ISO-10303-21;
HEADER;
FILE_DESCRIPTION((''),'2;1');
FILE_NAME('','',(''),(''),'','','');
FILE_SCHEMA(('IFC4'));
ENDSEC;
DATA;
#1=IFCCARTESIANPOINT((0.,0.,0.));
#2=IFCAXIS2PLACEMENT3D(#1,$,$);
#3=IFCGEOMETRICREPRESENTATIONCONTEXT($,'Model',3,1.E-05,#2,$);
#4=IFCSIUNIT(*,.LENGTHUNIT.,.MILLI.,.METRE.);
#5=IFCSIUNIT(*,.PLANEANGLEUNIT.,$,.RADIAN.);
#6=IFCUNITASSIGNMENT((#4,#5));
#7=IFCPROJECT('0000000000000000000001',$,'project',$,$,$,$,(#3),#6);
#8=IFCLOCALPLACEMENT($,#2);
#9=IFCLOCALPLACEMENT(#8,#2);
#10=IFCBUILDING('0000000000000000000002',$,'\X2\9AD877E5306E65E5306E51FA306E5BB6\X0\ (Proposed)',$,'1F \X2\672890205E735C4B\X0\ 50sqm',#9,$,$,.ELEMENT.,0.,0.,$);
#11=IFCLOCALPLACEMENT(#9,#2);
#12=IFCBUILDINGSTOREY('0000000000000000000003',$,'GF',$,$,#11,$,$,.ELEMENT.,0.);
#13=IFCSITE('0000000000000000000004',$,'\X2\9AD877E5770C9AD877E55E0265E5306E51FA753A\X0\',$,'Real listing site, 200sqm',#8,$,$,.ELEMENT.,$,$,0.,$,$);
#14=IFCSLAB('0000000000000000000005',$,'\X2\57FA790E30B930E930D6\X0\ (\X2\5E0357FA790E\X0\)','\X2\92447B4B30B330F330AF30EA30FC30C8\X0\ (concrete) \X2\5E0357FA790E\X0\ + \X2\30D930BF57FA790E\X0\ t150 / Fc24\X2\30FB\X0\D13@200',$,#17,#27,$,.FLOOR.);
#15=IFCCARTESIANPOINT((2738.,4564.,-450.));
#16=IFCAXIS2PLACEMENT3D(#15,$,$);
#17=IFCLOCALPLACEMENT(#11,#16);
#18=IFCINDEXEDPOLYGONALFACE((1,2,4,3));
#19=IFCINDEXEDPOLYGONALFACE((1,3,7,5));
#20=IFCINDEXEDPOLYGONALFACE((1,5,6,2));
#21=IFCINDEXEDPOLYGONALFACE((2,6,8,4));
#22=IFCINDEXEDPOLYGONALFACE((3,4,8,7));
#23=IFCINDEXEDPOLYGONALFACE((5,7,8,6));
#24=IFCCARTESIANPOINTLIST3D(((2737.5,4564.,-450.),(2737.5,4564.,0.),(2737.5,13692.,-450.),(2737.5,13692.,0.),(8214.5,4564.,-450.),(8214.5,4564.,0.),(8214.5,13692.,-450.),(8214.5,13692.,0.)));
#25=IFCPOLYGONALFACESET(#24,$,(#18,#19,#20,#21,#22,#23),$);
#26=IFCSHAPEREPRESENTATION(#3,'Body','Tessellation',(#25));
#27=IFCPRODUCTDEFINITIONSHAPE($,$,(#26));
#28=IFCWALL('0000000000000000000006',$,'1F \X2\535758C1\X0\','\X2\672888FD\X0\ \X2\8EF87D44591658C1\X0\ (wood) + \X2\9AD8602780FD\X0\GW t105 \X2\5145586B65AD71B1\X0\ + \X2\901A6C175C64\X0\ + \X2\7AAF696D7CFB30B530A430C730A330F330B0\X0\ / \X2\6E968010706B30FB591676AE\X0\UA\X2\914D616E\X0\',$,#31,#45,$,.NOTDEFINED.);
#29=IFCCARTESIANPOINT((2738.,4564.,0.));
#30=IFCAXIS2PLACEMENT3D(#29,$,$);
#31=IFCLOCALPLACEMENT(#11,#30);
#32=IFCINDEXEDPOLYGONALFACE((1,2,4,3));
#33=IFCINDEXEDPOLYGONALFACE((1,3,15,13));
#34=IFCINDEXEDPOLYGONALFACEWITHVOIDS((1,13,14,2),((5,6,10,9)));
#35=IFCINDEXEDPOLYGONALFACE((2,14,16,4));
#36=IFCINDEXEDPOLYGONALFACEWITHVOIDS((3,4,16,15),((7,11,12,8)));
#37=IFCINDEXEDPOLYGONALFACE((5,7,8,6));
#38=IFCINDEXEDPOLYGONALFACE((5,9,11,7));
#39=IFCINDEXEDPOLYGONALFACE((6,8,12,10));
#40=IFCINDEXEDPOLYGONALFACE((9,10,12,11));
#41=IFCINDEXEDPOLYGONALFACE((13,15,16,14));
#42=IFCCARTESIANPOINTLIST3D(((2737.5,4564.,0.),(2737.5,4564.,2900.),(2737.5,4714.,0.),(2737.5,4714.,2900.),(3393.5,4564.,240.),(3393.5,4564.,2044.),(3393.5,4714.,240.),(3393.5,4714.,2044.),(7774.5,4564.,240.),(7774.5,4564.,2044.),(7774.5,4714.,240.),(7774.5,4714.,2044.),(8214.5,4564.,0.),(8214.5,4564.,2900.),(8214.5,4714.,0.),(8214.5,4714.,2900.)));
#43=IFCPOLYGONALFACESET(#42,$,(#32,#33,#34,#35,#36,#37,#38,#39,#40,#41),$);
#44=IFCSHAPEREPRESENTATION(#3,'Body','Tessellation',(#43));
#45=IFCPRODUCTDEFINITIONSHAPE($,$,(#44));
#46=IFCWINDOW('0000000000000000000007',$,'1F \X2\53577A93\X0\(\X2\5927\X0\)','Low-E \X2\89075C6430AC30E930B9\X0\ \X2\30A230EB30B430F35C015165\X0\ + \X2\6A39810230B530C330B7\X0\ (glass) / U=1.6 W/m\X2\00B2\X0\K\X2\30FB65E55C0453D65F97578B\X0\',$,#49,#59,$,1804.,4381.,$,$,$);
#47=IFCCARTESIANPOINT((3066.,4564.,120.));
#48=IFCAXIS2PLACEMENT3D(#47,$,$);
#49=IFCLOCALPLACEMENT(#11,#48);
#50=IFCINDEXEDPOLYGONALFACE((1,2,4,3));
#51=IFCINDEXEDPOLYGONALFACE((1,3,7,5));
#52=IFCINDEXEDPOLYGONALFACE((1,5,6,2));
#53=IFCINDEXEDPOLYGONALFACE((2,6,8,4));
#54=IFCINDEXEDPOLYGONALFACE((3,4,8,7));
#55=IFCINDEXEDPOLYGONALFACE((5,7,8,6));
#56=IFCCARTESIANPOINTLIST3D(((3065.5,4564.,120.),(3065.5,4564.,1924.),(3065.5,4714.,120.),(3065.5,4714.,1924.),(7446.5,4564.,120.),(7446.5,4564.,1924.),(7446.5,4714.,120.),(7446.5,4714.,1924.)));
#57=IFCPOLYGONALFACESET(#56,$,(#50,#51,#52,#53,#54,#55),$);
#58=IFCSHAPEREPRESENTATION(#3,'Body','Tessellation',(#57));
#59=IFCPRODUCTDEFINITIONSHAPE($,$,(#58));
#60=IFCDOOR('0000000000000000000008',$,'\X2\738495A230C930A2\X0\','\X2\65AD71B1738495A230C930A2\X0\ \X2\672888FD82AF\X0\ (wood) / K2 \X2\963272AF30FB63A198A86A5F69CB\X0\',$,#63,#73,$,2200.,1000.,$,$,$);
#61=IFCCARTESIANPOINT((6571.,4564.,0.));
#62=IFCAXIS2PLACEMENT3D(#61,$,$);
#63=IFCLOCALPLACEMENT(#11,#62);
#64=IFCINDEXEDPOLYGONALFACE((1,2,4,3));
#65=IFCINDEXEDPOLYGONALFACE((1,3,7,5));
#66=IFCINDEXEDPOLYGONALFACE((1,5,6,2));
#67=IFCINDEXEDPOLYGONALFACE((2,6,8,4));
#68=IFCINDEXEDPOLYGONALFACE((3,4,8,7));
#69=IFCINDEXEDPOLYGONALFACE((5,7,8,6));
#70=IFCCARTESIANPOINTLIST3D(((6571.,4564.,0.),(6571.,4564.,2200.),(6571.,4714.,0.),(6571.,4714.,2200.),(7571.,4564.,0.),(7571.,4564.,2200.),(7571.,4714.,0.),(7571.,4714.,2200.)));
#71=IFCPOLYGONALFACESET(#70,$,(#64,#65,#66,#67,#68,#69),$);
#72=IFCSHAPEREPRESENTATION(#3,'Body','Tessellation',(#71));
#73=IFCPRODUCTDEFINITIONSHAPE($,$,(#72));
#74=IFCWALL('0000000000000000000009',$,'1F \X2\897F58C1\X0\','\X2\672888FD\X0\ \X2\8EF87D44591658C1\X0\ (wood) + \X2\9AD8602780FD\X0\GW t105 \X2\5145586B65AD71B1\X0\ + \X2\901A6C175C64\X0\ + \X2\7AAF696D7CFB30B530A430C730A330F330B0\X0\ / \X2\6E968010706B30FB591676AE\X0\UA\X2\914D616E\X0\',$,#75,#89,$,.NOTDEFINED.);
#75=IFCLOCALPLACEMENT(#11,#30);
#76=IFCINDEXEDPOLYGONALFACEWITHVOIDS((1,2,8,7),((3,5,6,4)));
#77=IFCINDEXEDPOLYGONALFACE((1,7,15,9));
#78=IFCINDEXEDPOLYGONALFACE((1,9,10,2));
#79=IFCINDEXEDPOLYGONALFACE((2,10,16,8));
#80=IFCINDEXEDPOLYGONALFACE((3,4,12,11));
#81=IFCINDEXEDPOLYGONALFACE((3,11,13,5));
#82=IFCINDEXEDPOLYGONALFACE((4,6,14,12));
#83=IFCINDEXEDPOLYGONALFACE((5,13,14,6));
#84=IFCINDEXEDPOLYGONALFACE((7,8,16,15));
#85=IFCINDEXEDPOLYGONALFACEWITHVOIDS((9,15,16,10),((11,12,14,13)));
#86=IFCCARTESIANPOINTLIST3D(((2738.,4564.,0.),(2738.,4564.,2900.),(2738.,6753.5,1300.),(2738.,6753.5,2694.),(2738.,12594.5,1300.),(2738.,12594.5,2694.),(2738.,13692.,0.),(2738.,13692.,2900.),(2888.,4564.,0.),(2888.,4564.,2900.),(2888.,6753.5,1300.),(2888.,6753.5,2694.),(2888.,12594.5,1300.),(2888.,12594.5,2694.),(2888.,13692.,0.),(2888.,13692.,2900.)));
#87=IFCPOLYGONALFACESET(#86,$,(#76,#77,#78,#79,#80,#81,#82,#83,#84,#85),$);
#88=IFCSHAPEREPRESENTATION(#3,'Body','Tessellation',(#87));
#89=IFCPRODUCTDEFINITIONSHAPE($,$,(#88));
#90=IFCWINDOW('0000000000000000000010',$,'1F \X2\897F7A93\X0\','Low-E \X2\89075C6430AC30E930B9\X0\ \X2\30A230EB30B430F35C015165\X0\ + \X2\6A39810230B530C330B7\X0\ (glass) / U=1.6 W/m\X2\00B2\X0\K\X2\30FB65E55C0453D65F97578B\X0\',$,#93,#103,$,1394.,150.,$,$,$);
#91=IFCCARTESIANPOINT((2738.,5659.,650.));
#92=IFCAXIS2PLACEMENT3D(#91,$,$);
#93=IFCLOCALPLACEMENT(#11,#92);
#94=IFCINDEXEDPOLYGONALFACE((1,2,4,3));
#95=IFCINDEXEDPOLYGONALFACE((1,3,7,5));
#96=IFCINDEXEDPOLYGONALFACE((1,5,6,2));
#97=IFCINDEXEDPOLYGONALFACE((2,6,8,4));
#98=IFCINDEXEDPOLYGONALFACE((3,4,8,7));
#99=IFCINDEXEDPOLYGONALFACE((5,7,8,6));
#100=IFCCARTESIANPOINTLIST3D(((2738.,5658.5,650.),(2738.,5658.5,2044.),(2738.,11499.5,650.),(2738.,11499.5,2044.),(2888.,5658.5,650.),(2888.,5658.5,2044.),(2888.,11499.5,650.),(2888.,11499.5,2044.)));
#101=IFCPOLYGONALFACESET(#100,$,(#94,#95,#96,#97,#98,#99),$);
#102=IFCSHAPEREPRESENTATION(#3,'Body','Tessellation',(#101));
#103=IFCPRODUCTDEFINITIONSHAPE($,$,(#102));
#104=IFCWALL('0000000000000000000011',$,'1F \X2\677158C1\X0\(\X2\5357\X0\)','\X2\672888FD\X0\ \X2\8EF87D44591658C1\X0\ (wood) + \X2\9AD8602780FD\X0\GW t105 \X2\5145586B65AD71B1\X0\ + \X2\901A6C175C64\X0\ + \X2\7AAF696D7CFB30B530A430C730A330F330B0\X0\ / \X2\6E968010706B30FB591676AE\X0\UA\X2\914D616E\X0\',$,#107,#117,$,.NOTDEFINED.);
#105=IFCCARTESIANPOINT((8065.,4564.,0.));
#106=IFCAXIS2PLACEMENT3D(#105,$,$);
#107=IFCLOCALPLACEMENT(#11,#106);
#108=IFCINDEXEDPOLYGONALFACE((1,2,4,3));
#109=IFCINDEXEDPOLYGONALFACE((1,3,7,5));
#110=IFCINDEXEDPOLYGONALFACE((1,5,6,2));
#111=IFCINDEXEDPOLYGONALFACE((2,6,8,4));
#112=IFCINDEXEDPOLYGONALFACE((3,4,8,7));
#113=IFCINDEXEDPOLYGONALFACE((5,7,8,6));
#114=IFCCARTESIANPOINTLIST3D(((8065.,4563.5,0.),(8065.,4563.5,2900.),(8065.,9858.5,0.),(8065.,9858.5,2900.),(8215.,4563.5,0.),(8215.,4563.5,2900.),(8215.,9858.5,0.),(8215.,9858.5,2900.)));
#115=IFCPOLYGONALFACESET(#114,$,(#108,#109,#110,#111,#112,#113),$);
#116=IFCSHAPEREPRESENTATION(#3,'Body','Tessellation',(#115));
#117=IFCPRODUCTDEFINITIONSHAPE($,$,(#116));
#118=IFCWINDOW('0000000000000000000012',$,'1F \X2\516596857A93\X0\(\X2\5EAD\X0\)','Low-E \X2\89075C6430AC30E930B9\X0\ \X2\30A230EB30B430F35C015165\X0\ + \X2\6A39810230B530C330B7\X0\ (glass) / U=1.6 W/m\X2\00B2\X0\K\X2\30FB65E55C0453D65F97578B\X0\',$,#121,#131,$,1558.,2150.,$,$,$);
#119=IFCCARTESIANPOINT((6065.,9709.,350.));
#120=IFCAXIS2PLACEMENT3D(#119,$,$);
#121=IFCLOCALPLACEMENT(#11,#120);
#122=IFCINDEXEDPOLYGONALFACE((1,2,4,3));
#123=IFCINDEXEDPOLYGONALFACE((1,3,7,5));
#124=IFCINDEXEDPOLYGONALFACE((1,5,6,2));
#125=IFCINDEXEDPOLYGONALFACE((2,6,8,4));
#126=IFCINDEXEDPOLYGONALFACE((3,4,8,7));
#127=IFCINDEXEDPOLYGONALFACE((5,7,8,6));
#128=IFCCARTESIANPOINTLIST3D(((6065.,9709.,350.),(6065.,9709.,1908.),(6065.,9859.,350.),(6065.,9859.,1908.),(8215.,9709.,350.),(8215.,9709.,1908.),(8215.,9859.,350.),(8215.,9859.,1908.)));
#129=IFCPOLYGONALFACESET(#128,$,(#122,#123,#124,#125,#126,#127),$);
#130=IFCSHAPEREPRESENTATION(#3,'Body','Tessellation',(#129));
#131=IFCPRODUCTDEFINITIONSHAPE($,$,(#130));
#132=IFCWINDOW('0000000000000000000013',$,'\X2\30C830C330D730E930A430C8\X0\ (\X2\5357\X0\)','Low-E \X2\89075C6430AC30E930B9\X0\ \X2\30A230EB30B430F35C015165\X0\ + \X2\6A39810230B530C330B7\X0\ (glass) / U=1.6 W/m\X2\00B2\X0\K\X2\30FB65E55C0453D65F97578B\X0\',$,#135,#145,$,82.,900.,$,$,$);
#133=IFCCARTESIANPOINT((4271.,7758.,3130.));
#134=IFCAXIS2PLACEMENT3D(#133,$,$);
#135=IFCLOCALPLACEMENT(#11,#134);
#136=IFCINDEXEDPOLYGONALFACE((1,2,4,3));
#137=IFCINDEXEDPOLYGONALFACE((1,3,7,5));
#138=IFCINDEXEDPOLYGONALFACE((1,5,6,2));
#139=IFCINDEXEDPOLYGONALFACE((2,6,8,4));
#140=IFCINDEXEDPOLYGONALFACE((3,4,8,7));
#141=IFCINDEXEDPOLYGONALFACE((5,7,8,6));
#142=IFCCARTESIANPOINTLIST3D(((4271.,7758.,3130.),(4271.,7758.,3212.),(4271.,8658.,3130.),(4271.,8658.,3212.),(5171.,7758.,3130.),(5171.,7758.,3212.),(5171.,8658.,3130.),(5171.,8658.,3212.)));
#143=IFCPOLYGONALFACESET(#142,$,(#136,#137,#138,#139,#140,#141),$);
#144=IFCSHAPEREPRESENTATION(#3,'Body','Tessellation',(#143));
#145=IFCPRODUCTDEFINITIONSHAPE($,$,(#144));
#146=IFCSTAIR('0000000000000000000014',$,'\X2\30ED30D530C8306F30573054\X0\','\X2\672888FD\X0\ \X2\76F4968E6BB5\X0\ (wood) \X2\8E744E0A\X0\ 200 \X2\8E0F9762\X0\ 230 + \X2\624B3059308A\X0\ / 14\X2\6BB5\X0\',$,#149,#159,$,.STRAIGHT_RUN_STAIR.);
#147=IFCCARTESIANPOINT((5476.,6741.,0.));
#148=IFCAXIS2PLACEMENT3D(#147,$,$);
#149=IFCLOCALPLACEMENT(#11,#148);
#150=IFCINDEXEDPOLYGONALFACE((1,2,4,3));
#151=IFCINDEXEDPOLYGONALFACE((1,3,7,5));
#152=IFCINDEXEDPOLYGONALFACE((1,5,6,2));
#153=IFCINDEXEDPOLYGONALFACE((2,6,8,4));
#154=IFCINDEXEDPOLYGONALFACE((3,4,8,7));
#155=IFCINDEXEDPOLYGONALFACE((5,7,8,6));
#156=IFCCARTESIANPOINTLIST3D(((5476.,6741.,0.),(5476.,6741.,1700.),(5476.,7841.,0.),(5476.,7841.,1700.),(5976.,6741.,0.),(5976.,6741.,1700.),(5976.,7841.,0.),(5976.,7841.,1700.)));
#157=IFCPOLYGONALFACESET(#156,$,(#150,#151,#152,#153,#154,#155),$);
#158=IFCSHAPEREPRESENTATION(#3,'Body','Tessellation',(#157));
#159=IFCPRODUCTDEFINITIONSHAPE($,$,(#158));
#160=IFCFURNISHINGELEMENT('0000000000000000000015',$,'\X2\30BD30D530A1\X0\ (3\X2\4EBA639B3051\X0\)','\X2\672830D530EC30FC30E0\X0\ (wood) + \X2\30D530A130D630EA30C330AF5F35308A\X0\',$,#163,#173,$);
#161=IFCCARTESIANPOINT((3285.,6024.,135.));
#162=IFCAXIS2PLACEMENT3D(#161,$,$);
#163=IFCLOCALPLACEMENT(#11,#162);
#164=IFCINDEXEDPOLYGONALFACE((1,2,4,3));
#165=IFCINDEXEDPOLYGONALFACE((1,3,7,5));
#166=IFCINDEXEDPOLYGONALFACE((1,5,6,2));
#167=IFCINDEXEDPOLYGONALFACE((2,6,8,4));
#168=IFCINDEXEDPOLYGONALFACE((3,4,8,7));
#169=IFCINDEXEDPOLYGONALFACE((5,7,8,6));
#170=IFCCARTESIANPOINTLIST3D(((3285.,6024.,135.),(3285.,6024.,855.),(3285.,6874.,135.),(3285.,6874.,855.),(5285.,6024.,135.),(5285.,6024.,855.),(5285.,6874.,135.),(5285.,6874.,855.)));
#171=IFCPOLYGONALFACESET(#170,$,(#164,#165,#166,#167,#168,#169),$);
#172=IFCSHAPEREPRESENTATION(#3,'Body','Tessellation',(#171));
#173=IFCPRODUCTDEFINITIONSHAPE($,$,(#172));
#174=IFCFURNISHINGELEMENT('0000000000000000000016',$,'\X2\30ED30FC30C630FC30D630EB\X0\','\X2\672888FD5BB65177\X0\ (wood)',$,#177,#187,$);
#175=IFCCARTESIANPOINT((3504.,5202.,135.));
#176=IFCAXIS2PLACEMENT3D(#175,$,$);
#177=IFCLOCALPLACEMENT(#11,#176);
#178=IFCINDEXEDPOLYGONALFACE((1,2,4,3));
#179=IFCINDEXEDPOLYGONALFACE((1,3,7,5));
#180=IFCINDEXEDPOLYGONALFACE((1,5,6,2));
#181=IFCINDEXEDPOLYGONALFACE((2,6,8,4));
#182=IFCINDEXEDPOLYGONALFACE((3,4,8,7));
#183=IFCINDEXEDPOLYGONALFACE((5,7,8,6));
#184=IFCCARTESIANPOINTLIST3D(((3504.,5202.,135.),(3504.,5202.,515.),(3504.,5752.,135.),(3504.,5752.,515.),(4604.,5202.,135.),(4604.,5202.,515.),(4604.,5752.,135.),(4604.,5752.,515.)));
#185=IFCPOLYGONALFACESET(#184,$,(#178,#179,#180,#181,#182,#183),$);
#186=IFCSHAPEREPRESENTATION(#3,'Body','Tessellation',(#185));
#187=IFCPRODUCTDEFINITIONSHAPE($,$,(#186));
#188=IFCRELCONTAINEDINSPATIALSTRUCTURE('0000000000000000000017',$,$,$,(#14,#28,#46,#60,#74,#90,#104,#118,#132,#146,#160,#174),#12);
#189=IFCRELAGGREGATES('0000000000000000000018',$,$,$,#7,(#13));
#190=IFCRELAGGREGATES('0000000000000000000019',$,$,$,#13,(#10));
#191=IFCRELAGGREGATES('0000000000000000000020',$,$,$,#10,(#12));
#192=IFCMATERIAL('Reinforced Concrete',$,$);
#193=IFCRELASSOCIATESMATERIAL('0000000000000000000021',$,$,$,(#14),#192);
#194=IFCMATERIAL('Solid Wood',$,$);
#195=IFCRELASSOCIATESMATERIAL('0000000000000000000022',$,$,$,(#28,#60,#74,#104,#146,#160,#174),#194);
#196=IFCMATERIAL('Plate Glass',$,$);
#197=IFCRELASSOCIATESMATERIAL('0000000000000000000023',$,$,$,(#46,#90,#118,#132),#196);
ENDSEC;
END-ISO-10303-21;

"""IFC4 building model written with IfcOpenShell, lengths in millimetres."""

from ifc_helpers import new_model, si_unit, frame, frame_2d, origin, place, context, project, spatial, rectangle, extrude, material, element, fill, save


model = new_model("IFC4")

# Units and contexts
model_context = context("Model", 3, precision=1e-05, world=origin())
ifc_project = project(units=[si_unit("LENGTHUNIT", "METRE", prefix="MILLI"), si_unit("PLANEANGLEUNIT", "RADIAN")], contexts=[model_context])

# Site, building, storey
site_placement = place(None, origin())
site = spatial("IfcSite", under=ifc_project, at=site_placement, Name="高知県高知市日の出町", ObjectType="Real listing site, 200sqm", CompositionType="ELEMENT", RefElevation=0.0)
building_placement = place(site_placement, origin())
building = spatial("IfcBuilding", under=site, at=building_placement, Name="高知の日の出の家 (Proposed)", ObjectType="1F 木造平屋 50sqm", CompositionType="ELEMENT", ElevationOfRefHeight=0.0, ElevationOfTerrain=0.0)
storey_placement = place(building_placement, origin())
storey = spatial("IfcBuildingStorey", under=building, at=storey_placement, Name="GF", CompositionType="ELEMENT", Elevation=0.0)

# Slab
ifc_material_1 = material(Name="Reinforced Concrete")
slab_1_placement = place(storey_placement, frame((2738.0, 4564.0, -450.0)))
element("IfcSlab", 1, at=slab_1_placement, inside=storey, material=ifc_material_1, Name="基礎スラブ (布基礎)", Description="鉄筋コンクリート (concrete) 布基礎 + ベタ基礎 t150 / Fc24・D13@200", PredefinedType="FLOOR", context=model_context, shape_type="SweptSolid", body=[
    extrude(rectangle(XDim=5477.0, YDim=9128.0, at=frame_2d((2738.0, 4564.0))), frame((2738.0, 4564.0, -450.0)), (0.0, 0.0, 1.0), 450.0),
])
ifc_material_2 = material(Name="Solid Wood")

# Wall, openings, window, door
wall_1_placement = place(storey_placement, frame((2738.0, 4564.0, 0.0)))
wall_1 = element("IfcWall", 2, at=wall_1_placement, inside=storey, material=ifc_material_2, Name="1F 南壁", Description="木製 軸組外壁 (wood) + 高性能GW t105 充填断熱 + 通気層 + 窯業系サイディング / 準耐火・外皮UA配慮", PredefinedType="NOTDEFINED", context=model_context, shape_type="SweptSolid", body=[
    extrude(rectangle(XDim=5477.0, YDim=150.0, at=frame_2d((2738.0, 75.0))), frame((2738.0, 4564.0, 0.0)), (0.0, 0.0, 1.0), 2900.0),
])
opening_1_placement = place(storey_placement, frame((3066.0, 4564.0, 120.0)))
opening_1 = element("IfcOpeningElement", 3, at=opening_1_placement, cuts=wall_1, PredefinedType="NOTDEFINED", context=model_context, shape_type="SweptSolid", body=[
    extrude(rectangle(XDim=4381.0, YDim=150.0, at=frame_2d((2190.0, 75.0))), frame((3066.0, 4564.0, 120.0)), (0.0, 0.0, 1.0), 1804.0),
])
opening_2_placement = place(storey_placement, frame((6571.0, 4564.0, 0.0)))
opening_2 = element("IfcOpeningElement", 4, at=opening_2_placement, cuts=wall_1, PredefinedType="NOTDEFINED", context=model_context, shape_type="SweptSolid", body=[
    extrude(rectangle(XDim=1000.0, YDim=150.0, at=frame_2d((500.0, 75.0))), frame((6571.0, 4564.0, 0.0)), (0.0, 0.0, 1.0), 2200.0),
])
ifc_material_3 = material(Name="Plate Glass")
window_1_placement = place(storey_placement, frame((3066.0, 4564.0, 120.0)))
window_1 = element("IfcWindow", 5, at=window_1_placement, inside=storey, material=ifc_material_3, Name="1F 南窓(大)", Description="Low-E 複層ガラス アルゴン封入 + 樹脂サッシ (glass) / U=1.6 W/m²K・日射取得型", OverallHeight=1804.0, OverallWidth=4381.0, context=model_context, shape_type="SweptSolid", body=[
    extrude(rectangle(XDim=4381.0, YDim=150.0, at=frame_2d((2190.0, 75.0))), frame((3066.0, 4564.0, 120.0)), (0.0, 0.0, 1.0), 1804.0),
])
fill(opening_1, window_1)
door_1_placement = place(storey_placement, frame((6571.0, 4564.0, 0.0)))
door_1 = element("IfcDoor", 6, at=door_1_placement, inside=storey, material=ifc_material_2, Name="玄関ドア", Description="断熱玄関ドア 木製芯 (wood) / K2 防犯・採風機構", OverallHeight=2200.0, OverallWidth=1000.0, context=model_context, shape_type="SweptSolid", body=[
    extrude(rectangle(XDim=1000.0, YDim=150.0, at=frame_2d((500.0, 75.0))), frame((6571.0, 4564.0, 0.0)), (0.0, 0.0, 1.0), 2200.0),
])
fill(opening_2, door_1)

# Walls, openings, windows
wall_2_placement = place(storey_placement, frame((2738.0, 4564.0, 0.0)))
wall_2 = element("IfcWall", 7, at=wall_2_placement, inside=storey, material=ifc_material_2, Name="1F 西壁", Description="木製 軸組外壁 (wood) + 高性能GW t105 充填断熱 + 通気層 + 窯業系サイディング / 準耐火・外皮UA配慮", PredefinedType="NOTDEFINED", context=model_context, shape_type="SweptSolid", body=[
    extrude(rectangle(XDim=150.0, YDim=9128.0, at=frame_2d((75.0, 4564.0))), frame((2738.0, 4564.0, 0.0)), (0.0, 0.0, 1.0), 2900.0),
])
opening_3_placement = place(storey_placement, frame((2738.0, 5659.0, 650.0)))
opening_3 = element("IfcOpeningElement", 8, at=opening_3_placement, cuts=wall_2, PredefinedType="NOTDEFINED", context=model_context, shape_type="SweptSolid", body=[
    extrude(rectangle(XDim=150.0, YDim=5841.0, at=frame_2d((75.0, 2920.0))), frame((2738.0, 5659.0, 650.0)), (0.0, 0.0, 1.0), 1394.0),
])
window_2_placement = place(storey_placement, frame((2738.0, 5659.0, 650.0)))
window_2 = element("IfcWindow", 9, at=window_2_placement, inside=storey, material=ifc_material_3, Name="1F 西窓", Description="Low-E 複層ガラス アルゴン封入 + 樹脂サッシ (glass) / U=1.6 W/m²K・日射取得型", OverallHeight=1394.0, OverallWidth=150.0, context=model_context, shape_type="SweptSolid", body=[
    extrude(rectangle(XDim=150.0, YDim=5841.0, at=frame_2d((75.0, 2920.0))), frame((2738.0, 5659.0, 650.0)), (0.0, 0.0, 1.0), 1394.0),
])
fill(opening_3, window_2)
wall_3_placement = place(storey_placement, frame((8065.0, 4564.0, 0.0)))
wall_3 = element("IfcWall", 10, at=wall_3_placement, inside=storey, material=ifc_material_2, Name="1F 東壁(南)", Description="木製 軸組外壁 (wood) + 高性能GW t105 充填断熱 + 通気層 + 窯業系サイディング / 準耐火・外皮UA配慮", PredefinedType="NOTDEFINED", context=model_context, shape_type="SweptSolid", body=[
    extrude(rectangle(XDim=150.0, YDim=5295.0, at=frame_2d((75.0, 2647.0))), frame((8065.0, 4564.0, 0.0)), (0.0, 0.0, 1.0), 2900.0),
])
opening_4_placement = place(storey_placement, frame((6065.0, 9709.0, 350.0)))
opening_4 = element("IfcOpeningElement", 11, at=opening_4_placement, cuts=wall_3, PredefinedType="NOTDEFINED", context=model_context, shape_type="SweptSolid", body=[
    extrude(rectangle(XDim=2150.0, YDim=150.0, at=frame_2d((1075.0, 75.0))), frame((6065.0, 9709.0, 350.0)), (0.0, 0.0, 1.0), 1558.0),
])
window_3_placement = place(storey_placement, frame((6065.0, 9709.0, 350.0)))
window_3 = element("IfcWindow", 12, at=window_3_placement, inside=storey, material=ifc_material_3, Name="1F 入隅窓(庭)", Description="Low-E 複層ガラス アルゴン封入 + 樹脂サッシ (glass) / U=1.6 W/m²K・日射取得型", OverallHeight=1558.0, OverallWidth=2150.0, context=model_context, shape_type="SweptSolid", body=[
    extrude(rectangle(XDim=2150.0, YDim=150.0, at=frame_2d((1075.0, 75.0))), frame((6065.0, 9709.0, 350.0)), (0.0, 0.0, 1.0), 1558.0),
])
fill(opening_4, window_3)

# Window
window_4_placement = place(storey_placement, frame((4271.0, 7758.0, 3130.0)))
element("IfcWindow", 13, at=window_4_placement, inside=storey, material=ifc_material_3, Name="トップライト (南)", Description="Low-E 複層ガラス アルゴン封入 + 樹脂サッシ (glass) / U=1.6 W/m²K・日射取得型", OverallHeight=82.0, OverallWidth=900.0, context=model_context, shape_type="SweptSolid", body=[
    extrude(rectangle(XDim=900.0, YDim=900.0, at=frame_2d((450.0, 450.0))), frame((4271.0, 7758.0, 3130.0)), (0.0, 0.0, 1.0), 82.0),
])

# Stair
stair_placement = place(storey_placement, frame((5476.0, 6741.0, 0.0)))
element("IfcStair", 14, at=stair_placement, inside=storey, material=ifc_material_2, Name="ロフトはしご", Description="木製 直階段 (wood) 蹴上 200 踏面 230 + 手すり / 14段", PredefinedType="STRAIGHT_RUN_STAIR", context=model_context, shape_type="SweptSolid", body=[
    extrude(rectangle(XDim=500.0, YDim=1100.0, at=frame_2d((250.0, 550.0))), frame((5476.0, 6741.0, 0.0)), (0.0, 0.0, 1.0), 1700.0),
])

# Furnishing elements
furnishing_1_placement = place(storey_placement, frame((3285.0, 6024.0, 135.0)))
element("IfcFurnishingElement", 15, at=furnishing_1_placement, inside=storey, material=ifc_material_2, Name="ソファ (3人掛け)", Description="木フレーム (wood) + ファブリック張り", context=model_context, shape_type="SweptSolid", body=[
    extrude(rectangle(XDim=2000.0, YDim=850.0, at=frame_2d((1000.0, 425.0))), frame((3285.0, 6024.0, 135.0)), (0.0, 0.0, 1.0), 720.0),
])
furnishing_2_placement = place(storey_placement, frame((3504.0, 5202.0, 135.0)))
element("IfcFurnishingElement", 16, at=furnishing_2_placement, inside=storey, material=ifc_material_2, Name="ローテーブル", Description="木製家具 (wood)", context=model_context, shape_type="SweptSolid", body=[
    extrude(rectangle(XDim=1100.0, YDim=550.0, at=frame_2d((550.0, 275.0))), frame((3504.0, 5202.0, 135.0)), (0.0, 0.0, 1.0), 380.0),
])

save(model, "model.ifc")
